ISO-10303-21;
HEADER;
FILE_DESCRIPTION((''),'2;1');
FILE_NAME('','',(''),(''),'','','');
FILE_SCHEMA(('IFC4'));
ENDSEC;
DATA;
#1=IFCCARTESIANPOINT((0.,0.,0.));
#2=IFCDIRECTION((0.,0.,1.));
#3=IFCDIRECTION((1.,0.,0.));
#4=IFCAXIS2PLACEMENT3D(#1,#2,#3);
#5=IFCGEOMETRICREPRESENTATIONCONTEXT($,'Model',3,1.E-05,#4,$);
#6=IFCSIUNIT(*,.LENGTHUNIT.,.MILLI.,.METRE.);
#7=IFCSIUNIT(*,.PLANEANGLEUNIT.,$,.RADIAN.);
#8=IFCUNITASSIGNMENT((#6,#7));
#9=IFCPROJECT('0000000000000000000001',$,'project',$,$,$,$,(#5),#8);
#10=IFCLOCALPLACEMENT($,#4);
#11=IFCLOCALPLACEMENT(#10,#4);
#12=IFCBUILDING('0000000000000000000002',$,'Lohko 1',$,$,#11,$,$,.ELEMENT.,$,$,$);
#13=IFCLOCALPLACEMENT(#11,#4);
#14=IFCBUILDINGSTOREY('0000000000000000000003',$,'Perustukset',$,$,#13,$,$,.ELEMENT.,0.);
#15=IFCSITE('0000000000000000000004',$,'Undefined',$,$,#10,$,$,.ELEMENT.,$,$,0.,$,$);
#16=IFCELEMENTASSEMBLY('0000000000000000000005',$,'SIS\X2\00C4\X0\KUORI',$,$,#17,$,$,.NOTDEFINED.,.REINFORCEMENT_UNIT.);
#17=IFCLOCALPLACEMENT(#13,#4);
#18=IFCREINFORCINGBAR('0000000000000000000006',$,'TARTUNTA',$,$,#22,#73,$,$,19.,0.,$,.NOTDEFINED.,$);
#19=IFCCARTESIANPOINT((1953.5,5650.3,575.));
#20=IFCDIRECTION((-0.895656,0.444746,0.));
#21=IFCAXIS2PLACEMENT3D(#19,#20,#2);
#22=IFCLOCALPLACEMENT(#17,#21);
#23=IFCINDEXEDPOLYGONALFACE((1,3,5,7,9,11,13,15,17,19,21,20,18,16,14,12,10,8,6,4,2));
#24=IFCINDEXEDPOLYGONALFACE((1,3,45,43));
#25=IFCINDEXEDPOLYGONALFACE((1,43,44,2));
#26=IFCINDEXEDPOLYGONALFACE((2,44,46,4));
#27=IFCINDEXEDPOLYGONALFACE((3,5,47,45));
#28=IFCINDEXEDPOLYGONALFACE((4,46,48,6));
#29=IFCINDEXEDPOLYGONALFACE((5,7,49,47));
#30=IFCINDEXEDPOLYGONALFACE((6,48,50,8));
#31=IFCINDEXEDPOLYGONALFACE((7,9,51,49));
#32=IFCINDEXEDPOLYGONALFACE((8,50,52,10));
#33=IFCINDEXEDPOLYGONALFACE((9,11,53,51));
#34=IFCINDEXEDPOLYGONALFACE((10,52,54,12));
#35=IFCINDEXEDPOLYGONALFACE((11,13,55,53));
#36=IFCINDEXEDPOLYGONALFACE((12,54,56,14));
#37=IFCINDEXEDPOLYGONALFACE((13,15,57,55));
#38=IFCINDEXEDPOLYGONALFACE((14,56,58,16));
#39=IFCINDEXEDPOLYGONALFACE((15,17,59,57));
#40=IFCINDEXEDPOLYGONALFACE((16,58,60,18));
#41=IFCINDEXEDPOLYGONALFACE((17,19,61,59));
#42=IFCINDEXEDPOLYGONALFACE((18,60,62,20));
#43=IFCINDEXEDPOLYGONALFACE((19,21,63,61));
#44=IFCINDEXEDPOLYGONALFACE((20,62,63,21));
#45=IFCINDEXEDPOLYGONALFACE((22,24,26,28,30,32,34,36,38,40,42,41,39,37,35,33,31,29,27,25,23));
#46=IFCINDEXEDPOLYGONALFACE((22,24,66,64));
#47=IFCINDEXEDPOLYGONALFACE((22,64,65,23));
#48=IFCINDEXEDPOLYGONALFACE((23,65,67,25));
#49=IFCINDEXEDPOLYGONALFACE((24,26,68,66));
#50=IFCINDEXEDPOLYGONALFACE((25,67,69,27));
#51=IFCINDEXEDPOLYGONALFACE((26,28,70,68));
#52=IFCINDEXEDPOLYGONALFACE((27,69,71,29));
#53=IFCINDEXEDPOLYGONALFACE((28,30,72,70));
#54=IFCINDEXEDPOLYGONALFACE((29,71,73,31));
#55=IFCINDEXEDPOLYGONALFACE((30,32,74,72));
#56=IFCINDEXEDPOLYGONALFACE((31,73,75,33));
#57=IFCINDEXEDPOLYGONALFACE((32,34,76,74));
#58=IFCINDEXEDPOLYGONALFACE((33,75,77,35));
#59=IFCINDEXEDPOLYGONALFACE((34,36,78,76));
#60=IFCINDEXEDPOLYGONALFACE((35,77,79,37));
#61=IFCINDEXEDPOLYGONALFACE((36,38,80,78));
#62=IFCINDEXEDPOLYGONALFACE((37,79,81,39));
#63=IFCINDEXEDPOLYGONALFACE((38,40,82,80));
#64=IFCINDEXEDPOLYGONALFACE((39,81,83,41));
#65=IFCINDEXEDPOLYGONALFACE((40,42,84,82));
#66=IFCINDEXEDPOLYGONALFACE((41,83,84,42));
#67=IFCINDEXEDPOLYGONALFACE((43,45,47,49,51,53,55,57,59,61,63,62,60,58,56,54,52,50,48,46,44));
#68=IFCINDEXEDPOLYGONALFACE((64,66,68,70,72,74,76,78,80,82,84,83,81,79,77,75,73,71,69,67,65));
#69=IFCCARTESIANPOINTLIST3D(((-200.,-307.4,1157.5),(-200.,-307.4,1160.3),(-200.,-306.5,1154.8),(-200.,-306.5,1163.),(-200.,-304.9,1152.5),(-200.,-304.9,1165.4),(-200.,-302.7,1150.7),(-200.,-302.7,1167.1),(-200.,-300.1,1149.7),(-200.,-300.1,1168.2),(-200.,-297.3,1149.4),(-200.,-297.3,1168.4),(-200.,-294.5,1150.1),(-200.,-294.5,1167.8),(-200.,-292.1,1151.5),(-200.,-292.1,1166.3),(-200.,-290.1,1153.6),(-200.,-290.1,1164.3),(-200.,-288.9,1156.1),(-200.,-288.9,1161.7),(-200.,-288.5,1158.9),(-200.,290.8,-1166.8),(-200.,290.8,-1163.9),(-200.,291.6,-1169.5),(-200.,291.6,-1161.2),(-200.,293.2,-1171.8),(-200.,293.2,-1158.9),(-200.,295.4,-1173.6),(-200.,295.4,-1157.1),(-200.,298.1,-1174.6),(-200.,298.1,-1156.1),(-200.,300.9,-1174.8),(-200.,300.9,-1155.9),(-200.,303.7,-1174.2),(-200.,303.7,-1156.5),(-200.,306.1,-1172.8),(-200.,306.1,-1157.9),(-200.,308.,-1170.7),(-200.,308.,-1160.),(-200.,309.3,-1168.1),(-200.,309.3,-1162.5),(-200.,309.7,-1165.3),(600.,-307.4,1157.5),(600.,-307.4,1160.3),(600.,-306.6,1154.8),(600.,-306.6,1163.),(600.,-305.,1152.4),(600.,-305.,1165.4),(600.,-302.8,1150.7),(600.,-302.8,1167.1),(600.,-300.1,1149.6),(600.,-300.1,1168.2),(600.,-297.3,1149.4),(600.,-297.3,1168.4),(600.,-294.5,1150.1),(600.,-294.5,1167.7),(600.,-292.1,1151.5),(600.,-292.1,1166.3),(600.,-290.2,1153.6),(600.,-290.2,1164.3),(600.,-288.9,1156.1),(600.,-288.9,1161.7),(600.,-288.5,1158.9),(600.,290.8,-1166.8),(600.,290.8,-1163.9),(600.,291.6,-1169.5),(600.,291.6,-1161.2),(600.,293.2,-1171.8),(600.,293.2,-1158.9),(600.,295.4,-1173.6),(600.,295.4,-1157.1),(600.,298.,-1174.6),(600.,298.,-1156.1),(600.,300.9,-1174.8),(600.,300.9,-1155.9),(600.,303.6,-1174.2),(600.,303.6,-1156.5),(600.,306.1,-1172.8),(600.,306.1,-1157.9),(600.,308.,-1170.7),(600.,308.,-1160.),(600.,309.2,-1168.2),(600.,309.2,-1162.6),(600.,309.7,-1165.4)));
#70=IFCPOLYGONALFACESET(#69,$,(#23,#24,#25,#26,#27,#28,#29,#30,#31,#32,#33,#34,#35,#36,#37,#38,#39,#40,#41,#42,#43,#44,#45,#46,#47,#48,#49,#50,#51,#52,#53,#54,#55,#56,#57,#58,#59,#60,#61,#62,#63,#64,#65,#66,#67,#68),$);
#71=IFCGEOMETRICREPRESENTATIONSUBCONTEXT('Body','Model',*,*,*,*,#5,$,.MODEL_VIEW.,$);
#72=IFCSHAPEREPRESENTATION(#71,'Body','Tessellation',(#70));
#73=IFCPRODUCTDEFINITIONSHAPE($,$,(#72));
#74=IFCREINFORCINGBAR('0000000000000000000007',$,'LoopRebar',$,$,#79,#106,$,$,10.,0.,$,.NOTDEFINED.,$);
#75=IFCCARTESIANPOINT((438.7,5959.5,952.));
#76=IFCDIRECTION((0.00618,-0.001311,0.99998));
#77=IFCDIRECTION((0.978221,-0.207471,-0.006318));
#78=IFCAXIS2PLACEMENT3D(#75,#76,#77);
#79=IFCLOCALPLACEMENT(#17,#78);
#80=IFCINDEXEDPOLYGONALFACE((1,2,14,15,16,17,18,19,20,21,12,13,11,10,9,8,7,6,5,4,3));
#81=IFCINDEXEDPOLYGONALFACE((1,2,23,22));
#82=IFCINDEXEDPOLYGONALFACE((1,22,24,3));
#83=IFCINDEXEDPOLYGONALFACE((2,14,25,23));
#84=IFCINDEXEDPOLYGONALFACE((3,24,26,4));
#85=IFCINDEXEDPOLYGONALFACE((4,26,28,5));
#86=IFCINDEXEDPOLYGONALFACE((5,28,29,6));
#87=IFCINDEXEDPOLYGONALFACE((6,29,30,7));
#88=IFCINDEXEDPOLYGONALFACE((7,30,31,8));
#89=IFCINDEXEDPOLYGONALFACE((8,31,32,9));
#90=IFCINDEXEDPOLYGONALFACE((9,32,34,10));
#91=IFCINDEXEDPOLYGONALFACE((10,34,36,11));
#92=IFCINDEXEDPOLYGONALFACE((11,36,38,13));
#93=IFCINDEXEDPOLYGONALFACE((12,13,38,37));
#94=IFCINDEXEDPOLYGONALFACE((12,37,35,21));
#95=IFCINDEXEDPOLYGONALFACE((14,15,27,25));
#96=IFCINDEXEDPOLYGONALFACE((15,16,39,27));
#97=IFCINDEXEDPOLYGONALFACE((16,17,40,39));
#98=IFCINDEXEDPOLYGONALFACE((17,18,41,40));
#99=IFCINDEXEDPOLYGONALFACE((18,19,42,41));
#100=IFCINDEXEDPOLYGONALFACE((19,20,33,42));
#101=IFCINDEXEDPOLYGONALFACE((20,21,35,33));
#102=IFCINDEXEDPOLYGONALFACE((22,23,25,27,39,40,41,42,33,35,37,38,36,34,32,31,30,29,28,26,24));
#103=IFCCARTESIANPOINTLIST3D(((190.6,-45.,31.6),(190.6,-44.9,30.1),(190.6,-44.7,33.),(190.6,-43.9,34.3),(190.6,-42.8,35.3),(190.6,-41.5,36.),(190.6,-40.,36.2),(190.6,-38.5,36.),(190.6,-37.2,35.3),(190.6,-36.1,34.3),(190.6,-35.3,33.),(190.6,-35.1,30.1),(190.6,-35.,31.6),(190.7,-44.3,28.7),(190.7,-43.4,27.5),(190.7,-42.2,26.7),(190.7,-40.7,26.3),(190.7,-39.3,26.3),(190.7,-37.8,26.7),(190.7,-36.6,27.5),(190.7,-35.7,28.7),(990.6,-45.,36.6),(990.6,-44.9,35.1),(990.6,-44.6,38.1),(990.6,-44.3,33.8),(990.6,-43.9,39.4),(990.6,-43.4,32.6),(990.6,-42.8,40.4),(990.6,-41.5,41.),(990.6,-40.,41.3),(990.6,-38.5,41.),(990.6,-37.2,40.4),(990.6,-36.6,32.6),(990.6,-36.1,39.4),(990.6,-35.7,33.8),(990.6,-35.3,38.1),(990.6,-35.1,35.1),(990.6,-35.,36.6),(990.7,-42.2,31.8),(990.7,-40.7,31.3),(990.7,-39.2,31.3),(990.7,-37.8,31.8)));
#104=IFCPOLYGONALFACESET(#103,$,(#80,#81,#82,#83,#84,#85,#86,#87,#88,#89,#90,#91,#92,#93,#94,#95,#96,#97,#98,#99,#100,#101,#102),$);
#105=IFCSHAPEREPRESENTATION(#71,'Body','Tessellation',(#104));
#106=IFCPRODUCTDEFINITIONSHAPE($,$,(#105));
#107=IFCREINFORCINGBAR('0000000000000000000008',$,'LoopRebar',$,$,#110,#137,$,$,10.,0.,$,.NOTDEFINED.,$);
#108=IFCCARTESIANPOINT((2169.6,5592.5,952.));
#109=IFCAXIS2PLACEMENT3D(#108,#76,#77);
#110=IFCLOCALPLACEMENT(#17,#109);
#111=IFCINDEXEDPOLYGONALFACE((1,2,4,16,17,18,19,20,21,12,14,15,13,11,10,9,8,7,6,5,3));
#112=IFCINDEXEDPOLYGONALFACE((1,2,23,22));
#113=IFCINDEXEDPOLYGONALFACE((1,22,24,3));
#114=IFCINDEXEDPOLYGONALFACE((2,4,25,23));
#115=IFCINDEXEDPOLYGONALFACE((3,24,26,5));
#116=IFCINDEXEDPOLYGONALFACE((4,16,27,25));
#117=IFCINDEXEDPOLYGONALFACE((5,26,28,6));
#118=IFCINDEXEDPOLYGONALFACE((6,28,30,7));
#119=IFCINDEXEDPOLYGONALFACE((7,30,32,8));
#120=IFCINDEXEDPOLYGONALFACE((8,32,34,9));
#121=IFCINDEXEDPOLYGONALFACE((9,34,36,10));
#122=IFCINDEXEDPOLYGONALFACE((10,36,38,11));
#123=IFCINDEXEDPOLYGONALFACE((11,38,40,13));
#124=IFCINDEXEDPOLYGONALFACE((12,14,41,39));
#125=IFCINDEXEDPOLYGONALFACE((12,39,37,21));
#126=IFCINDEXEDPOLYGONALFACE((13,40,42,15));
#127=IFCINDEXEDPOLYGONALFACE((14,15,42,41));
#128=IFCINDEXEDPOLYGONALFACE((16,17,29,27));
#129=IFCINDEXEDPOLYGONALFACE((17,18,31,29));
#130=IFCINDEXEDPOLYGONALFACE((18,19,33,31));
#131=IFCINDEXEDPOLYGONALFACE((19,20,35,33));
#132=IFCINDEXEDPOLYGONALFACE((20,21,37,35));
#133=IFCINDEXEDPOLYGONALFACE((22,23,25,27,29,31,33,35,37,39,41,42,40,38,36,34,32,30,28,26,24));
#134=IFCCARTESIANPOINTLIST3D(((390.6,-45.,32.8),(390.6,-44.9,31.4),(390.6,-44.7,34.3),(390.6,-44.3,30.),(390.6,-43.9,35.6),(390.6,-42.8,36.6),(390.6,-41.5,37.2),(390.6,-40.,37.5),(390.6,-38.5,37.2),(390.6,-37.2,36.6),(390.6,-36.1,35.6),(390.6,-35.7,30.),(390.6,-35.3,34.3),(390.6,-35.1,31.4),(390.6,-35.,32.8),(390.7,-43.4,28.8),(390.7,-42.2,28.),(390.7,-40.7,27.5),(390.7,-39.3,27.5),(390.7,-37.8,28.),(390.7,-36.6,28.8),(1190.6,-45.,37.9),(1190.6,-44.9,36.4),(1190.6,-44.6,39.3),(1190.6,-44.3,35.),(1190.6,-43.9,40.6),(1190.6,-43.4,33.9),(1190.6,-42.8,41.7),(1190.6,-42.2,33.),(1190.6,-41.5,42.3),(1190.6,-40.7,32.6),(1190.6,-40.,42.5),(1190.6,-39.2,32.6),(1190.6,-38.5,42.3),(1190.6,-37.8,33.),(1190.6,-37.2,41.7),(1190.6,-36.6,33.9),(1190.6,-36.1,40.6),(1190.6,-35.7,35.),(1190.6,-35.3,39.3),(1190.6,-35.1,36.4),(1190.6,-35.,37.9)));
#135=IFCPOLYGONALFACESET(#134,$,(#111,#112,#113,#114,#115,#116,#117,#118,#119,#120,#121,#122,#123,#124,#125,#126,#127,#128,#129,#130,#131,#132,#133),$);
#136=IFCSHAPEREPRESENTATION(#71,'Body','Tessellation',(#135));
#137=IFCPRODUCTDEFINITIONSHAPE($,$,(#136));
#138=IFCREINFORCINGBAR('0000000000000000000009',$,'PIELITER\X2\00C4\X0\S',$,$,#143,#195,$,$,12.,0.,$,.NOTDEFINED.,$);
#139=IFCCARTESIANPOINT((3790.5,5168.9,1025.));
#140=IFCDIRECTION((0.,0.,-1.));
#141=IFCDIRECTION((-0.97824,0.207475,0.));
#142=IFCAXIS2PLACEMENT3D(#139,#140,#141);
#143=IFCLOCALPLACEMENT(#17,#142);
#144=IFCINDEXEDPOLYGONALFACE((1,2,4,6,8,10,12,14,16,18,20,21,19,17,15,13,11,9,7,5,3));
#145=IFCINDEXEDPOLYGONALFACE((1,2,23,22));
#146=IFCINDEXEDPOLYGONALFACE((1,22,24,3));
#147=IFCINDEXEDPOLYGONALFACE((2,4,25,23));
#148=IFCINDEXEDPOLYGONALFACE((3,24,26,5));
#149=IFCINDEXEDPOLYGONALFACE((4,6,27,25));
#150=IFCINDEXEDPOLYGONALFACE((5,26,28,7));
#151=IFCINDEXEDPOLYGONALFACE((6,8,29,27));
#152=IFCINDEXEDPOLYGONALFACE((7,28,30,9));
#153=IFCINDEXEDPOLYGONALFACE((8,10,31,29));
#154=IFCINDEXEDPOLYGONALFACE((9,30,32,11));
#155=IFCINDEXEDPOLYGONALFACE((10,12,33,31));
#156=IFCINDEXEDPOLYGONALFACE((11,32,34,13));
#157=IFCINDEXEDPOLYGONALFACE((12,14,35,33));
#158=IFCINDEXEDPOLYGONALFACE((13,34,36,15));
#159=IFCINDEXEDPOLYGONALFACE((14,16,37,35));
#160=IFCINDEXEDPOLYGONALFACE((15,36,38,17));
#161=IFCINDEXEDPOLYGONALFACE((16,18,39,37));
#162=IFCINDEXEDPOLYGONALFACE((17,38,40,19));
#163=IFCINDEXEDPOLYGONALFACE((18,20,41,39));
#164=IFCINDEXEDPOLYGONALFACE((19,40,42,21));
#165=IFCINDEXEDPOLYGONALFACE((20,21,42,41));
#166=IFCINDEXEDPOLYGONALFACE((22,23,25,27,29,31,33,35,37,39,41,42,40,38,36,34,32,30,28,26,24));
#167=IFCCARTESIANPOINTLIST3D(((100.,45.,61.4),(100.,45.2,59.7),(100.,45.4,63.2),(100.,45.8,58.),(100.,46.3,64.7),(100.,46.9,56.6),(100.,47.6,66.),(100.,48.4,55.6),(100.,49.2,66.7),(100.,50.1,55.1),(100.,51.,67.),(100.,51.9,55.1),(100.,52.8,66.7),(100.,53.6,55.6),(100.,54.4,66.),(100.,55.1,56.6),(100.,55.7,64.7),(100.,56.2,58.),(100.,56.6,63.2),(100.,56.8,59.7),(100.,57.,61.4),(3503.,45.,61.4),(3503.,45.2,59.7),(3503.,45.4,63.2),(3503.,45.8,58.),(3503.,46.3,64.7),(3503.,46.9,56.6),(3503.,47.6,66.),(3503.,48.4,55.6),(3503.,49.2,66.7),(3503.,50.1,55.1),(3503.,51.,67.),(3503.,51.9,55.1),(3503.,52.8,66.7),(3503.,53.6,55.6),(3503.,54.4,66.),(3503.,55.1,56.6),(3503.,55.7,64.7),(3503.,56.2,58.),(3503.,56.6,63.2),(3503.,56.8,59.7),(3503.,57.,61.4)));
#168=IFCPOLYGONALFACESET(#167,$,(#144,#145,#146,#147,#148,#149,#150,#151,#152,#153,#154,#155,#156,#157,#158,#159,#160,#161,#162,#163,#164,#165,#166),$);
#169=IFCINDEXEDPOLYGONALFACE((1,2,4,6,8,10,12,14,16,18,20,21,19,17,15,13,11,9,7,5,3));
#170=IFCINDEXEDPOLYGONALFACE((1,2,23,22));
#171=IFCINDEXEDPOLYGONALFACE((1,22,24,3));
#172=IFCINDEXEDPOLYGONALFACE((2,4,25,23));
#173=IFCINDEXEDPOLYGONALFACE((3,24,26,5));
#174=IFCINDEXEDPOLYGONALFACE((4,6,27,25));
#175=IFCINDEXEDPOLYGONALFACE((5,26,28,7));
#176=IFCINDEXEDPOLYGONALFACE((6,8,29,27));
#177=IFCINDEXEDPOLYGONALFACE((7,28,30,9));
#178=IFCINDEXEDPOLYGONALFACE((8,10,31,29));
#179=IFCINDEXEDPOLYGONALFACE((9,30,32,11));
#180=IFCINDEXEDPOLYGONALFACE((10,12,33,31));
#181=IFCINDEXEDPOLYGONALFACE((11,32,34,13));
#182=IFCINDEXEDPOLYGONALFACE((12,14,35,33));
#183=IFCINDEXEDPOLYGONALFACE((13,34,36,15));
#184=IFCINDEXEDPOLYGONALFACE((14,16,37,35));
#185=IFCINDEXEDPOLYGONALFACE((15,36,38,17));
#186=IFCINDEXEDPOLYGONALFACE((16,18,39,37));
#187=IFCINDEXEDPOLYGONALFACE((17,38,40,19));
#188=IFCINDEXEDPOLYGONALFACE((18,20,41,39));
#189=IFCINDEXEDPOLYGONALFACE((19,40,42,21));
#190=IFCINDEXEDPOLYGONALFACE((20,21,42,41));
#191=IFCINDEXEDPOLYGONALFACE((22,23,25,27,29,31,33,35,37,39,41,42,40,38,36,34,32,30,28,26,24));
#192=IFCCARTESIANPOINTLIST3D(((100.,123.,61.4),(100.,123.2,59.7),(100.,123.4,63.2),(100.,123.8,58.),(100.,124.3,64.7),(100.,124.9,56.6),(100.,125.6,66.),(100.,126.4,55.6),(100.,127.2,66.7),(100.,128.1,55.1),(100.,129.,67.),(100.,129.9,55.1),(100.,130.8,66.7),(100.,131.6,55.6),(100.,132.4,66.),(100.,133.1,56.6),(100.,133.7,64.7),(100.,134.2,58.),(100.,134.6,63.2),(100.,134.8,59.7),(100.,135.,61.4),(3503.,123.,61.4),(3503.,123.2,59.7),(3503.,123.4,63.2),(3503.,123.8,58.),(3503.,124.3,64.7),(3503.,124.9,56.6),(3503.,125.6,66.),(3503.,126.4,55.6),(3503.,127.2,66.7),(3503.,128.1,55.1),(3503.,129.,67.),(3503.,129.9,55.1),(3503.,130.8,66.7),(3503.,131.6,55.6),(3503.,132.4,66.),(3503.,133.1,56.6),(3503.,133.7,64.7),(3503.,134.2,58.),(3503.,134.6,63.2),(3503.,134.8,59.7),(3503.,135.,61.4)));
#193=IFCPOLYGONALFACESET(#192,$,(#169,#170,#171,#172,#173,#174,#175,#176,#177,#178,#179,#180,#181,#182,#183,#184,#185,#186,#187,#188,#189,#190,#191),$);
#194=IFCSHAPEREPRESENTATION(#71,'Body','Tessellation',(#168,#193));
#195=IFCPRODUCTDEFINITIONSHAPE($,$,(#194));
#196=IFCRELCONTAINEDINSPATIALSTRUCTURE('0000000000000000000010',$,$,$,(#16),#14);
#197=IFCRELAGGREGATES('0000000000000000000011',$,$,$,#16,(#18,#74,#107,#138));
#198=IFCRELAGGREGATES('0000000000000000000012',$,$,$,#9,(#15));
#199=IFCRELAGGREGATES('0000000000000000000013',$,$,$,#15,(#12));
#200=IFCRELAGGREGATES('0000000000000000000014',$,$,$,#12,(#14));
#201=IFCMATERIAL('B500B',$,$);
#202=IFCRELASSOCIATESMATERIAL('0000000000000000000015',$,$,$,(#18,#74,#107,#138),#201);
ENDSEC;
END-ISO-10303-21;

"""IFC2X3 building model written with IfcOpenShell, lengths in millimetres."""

from ifc_helpers import new_model, entity, si_unit, frame, origin_with_axes, place, context, subcontext, project, spatial, source, transform, mapped, material, element, aggregate, save


model = new_model("IFC2X3")

# Units and contexts
model_context = context("Model", 3, precision=1e-05, world=origin_with_axes())
body_context = subcontext(model_context, "Body", "Model", "MODEL_VIEW")
ifc_project = project(units=[si_unit("LENGTHUNIT", "METRE", prefix="MILLI"), si_unit("PLANEANGLEUNIT", "RADIAN")], contexts=[model_context])

# Site, building, storey
site_placement = place(None, origin_with_axes())
site = spatial("IfcSite", under=ifc_project, at=site_placement, Name="Undefined", CompositionType="ELEMENT", RefElevation=0.0)
building_placement = place(site_placement, origin_with_axes())
building = spatial("IfcBuilding", under=site, at=building_placement, Name="Lohko 1", CompositionType="ELEMENT")
storey_placement = place(building_placement, origin_with_axes())
storey = spatial("IfcBuildingStorey", under=building, at=storey_placement, Name="Perustukset", CompositionType="ELEMENT", Elevation=0.0)

# Element assembly, reinforcing bars
assembly_placement = place(storey_placement, origin_with_axes())
assembly = element("IfcElementAssembly", 1, at=assembly_placement, inside=storey, Name="SISÄKUORI", AssemblyPlace="NOTDEFINED", PredefinedType="REINFORCEMENT_UNIT")
ifc_material_1 = material(Name="B500B")
shared_shape_1 = source(origin_with_axes(), body_context, "Body", "AdvancedSweptSolid", [
    entity("IfcSweptDiskSolid", entity("IfcTrimmedCurve", entity("IfcLine", entity("IfcCartesianPoint", [0.0, 0.0, 0.0]), entity("IfcVector", entity("IfcDirection", [1.0, -0.000038, -0.000013]), 1.0)), [entity("IfcParameterValue", 0.0)], [entity("IfcParameterValue", 799.999995)], True, "PARAMETER"), 9.5, None, 0.0, 800.0),
])
shared_shape_2 = source(origin_with_axes(), body_context, "Body", "AdvancedSweptSolid", [
    entity("IfcSweptDiskSolid", entity("IfcTrimmedCurve", entity("IfcLine", entity("IfcCartesianPoint", [0.0, 0.0, 0.0]), entity("IfcVector", entity("IfcDirection", [1.0, -0.000038, -0.000013]), 1.0)), [entity("IfcParameterValue", 0.0)], [entity("IfcParameterValue", 799.999995)], True, "PARAMETER"), 9.5, None, 0.0, 800.0),
])
reinforcing_bar_1_placement = place(assembly_placement, frame((1953.5, 5650.3, 575.0), z_axis=(-0.895656, 0.444746, 0.0), x_axis=(0.0, 0.0, 1.0)))
reinforcing_bar_1 = element("IfcReinforcingBar", 2, at=reinforcing_bar_1_placement, material=ifc_material_1, Name="TARTUNTA", BarRole="NOTDEFINED", CrossSectionArea=0.0, NominalDiameter=19.0, context=body_context, shape_type="MappedRepresentation", body=[
    mapped(shared_shape_1, transform((-200.0, -298.0, 1158.9))),
    mapped(shared_shape_2, transform((-200.0, 300.2, -1165.3))),
])
shared_shape_3 = source(origin_with_axes(), body_context, "Body", "AdvancedSweptSolid", [
    entity("IfcSweptDiskSolid", entity("IfcTrimmedCurve", entity("IfcLine", entity("IfcCartesianPoint", [0.0, 0.0, 0.0]), entity("IfcVector", entity("IfcDirection", [0.99998, 0.000011, 0.006318]), 1.0)), [entity("IfcParameterValue", 0.0)], [entity("IfcParameterValue", 800.001637)], True, "PARAMETER"), 5.0, None, 0.0, 800.0),
])
reinforcing_bar_2_placement = place(assembly_placement, frame((438.7, 5959.5, 952.0), z_axis=(0.00618, -0.001311, 0.99998), x_axis=(0.978221, -0.207471, -0.006318)))
reinforcing_bar_2 = element("IfcReinforcingBar", 3, at=reinforcing_bar_2_placement, material=ifc_material_1, Name="LoopRebar", BarRole="NOTDEFINED", CrossSectionArea=0.0, NominalDiameter=10.0, context=body_context, shape_type="MappedRepresentation", body=[
    mapped(shared_shape_3, transform((190.6, -40.0, 31.2))),
])
shared_shape_4 = source(origin_with_axes(), body_context, "Body", "AdvancedSweptSolid", [
    entity("IfcSweptDiskSolid", entity("IfcTrimmedCurve", entity("IfcLine", entity("IfcCartesianPoint", [0.0, 0.0, 0.0]), entity("IfcVector", entity("IfcDirection", [0.99998, 0.000011, 0.006318]), 1.0)), [entity("IfcParameterValue", 0.0)], [entity("IfcParameterValue", 800.001637)], True, "PARAMETER"), 5.0, None, 0.0, 800.0),
])
reinforcing_bar_3_placement = place(assembly_placement, frame((2169.6, 5592.5, 952.0), z_axis=(0.00618, -0.001311, 0.99998), x_axis=(0.978221, -0.207471, -0.006318)))
reinforcing_bar_3 = element("IfcReinforcingBar", 4, at=reinforcing_bar_3_placement, material=ifc_material_1, Name="LoopRebar", BarRole="NOTDEFINED", CrossSectionArea=0.0, NominalDiameter=10.0, context=body_context, shape_type="MappedRepresentation", body=[
    mapped(shared_shape_4, transform((390.6, -40.0, 32.5))),
])
shared_shape_5 = source(origin_with_axes(), body_context, "Body", "AdvancedSweptSolid", [
    entity("IfcSweptDiskSolid", entity("IfcTrimmedCurve", entity("IfcLine", entity("IfcCartesianPoint", [0.0, 0.0, 0.0]), entity("IfcVector", entity("IfcDirection", [1.0, 0.0, 0.0]), 1.0)), [entity("IfcParameterValue", 0.0)], [entity("IfcParameterValue", 3402.999984)], True, "PARAMETER"), 6.0, None, 0.0, 3403.0),
])
shared_shape_6 = source(origin_with_axes(), body_context, "Body", "AdvancedSweptSolid", [
    entity("IfcSweptDiskSolid", entity("IfcTrimmedCurve", entity("IfcLine", entity("IfcCartesianPoint", [0.0, 0.0, 0.0]), entity("IfcVector", entity("IfcDirection", [1.0, 0.0, 0.0]), 1.0)), [entity("IfcParameterValue", 0.0)], [entity("IfcParameterValue", 3402.999984)], True, "PARAMETER"), 6.0, None, 0.0, 3403.0),
])
reinforcing_bar_4_placement = place(assembly_placement, frame((3790.5, 5168.9, 1025.0), z_axis=(0.0, 0.0, -1.0), x_axis=(-0.97824, 0.207475, 0.0)))
reinforcing_bar_4 = element("IfcReinforcingBar", 5, at=reinforcing_bar_4_placement, material=ifc_material_1, Name="PIELITERÄS", BarRole="NOTDEFINED", CrossSectionArea=0.0, NominalDiameter=12.0, context=body_context, shape_type="MappedRepresentation", body=[
    mapped(shared_shape_5, transform((100.0, 51.0, 61.0))),
    mapped(shared_shape_6, transform((100.0, 129.0, 61.0))),
])
aggregate(assembly, [reinforcing_bar_1, reinforcing_bar_2, reinforcing_bar_3, reinforcing_bar_4])

save(model, "model.ifc")
